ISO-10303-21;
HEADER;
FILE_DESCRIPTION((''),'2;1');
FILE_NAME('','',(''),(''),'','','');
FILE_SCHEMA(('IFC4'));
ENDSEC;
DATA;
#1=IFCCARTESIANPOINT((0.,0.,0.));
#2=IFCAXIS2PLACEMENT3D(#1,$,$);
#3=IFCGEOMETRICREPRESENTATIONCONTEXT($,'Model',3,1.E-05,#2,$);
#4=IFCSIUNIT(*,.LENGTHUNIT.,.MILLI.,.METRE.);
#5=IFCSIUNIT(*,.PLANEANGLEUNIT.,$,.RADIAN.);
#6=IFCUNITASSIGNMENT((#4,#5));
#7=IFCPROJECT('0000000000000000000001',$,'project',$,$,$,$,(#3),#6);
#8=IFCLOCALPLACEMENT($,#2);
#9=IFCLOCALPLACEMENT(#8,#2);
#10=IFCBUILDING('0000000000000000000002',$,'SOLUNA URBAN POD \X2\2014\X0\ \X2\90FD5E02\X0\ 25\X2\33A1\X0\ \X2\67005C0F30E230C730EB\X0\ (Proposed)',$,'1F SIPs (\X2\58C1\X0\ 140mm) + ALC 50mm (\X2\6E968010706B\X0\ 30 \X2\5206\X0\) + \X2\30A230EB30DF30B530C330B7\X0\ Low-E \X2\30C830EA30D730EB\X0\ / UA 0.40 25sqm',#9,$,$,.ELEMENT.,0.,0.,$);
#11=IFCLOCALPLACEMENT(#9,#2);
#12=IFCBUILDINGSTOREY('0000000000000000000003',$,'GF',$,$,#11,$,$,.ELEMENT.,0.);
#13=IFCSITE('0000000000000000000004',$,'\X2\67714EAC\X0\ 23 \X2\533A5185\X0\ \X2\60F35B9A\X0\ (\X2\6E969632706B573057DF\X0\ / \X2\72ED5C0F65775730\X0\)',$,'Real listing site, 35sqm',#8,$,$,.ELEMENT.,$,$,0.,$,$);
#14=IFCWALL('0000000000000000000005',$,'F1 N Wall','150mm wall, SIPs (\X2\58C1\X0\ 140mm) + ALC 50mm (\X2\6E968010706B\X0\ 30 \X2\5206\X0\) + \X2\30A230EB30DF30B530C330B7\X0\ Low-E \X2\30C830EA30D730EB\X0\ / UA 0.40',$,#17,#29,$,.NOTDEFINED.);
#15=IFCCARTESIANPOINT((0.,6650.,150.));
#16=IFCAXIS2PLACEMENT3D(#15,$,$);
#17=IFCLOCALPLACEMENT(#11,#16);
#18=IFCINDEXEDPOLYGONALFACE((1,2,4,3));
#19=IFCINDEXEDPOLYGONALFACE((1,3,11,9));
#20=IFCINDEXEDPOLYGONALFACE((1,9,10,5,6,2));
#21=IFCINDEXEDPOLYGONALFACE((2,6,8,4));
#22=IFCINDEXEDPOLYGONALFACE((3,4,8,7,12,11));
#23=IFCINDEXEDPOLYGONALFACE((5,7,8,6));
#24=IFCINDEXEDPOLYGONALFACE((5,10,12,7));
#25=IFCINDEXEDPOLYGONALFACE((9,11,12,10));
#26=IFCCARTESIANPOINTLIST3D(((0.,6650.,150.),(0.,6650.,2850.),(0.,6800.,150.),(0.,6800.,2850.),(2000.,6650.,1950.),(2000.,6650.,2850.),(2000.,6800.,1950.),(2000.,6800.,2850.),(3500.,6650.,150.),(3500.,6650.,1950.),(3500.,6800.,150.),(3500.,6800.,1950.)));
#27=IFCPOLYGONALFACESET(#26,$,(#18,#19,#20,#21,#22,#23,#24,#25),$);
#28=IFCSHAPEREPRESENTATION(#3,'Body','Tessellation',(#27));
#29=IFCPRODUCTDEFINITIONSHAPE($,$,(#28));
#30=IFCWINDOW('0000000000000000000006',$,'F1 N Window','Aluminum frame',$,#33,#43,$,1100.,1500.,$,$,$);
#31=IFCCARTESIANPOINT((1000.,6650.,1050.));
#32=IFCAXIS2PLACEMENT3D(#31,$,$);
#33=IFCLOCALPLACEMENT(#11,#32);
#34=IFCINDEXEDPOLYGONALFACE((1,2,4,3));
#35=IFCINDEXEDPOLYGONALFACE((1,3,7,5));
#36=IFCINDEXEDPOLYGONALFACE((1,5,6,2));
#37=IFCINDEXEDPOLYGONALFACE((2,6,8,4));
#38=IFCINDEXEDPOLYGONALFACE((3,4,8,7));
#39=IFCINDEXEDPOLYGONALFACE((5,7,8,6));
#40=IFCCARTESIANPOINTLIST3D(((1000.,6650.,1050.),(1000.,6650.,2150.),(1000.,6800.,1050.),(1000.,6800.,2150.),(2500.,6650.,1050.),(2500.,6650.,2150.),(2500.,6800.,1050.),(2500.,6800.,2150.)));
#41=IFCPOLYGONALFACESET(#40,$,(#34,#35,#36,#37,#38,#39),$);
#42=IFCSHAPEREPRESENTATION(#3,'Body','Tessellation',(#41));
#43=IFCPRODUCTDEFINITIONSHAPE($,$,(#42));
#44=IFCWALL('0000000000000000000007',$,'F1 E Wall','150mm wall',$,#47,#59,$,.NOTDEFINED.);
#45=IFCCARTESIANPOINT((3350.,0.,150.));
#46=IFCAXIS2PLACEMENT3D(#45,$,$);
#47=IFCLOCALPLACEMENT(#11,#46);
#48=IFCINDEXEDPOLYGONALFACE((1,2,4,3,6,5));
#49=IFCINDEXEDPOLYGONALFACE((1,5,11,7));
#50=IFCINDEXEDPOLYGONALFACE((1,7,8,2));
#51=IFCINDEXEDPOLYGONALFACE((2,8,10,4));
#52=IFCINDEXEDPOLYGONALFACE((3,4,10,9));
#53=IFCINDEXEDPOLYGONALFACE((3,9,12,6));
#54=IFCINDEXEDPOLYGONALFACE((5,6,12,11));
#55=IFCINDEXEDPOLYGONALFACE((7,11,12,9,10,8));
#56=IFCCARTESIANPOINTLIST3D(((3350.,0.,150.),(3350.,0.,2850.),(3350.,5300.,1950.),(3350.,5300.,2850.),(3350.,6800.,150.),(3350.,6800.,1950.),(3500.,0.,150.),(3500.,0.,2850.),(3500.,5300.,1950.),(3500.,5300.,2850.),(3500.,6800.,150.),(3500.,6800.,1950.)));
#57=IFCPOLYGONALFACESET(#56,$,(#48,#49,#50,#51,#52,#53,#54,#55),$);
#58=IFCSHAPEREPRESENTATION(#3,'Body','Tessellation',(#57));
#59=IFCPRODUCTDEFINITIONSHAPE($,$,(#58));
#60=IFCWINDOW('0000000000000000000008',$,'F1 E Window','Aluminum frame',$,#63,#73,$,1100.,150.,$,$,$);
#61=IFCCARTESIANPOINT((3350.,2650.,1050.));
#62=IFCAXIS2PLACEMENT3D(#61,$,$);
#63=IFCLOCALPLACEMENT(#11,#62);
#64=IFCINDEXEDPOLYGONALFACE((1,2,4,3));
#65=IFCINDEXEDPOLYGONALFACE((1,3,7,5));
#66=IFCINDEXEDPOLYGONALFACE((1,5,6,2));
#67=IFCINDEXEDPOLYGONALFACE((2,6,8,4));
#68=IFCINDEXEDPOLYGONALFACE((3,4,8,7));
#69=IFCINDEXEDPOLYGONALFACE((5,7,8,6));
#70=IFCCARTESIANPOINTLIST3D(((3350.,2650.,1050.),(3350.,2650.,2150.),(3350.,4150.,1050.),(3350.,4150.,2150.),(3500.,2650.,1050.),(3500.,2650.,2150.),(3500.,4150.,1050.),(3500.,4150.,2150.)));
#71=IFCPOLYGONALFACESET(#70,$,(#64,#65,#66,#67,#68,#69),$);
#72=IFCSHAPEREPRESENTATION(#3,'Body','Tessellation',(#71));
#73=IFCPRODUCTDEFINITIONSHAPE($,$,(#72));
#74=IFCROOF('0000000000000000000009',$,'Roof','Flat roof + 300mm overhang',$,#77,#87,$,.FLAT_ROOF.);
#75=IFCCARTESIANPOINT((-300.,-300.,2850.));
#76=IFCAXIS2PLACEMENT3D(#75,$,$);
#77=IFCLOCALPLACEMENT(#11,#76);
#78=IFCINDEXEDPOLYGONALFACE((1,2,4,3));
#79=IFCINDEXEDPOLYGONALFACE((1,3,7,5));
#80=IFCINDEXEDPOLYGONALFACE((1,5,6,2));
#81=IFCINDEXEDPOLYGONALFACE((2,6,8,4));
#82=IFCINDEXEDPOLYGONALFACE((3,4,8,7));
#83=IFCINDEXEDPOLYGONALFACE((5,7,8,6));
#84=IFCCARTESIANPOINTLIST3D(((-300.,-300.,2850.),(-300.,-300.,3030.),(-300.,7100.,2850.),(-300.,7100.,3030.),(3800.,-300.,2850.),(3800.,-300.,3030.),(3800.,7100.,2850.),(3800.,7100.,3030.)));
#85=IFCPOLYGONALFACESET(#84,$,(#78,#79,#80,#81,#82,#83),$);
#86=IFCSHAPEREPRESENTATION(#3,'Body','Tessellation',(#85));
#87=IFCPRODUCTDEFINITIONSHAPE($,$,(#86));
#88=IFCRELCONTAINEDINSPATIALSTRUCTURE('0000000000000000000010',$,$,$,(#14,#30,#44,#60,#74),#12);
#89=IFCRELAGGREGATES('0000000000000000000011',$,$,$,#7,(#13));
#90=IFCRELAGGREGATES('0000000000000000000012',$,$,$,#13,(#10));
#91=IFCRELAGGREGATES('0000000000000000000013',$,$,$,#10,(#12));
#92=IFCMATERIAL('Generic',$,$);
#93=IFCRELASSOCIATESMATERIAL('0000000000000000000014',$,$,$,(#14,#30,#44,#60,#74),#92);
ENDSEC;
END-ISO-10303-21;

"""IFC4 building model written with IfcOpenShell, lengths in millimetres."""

from ifc_helpers import new_model, si_unit, frame, frame_2d, origin, place, context, project, spatial, rectangle, extrude, material, element, fill, save


model = new_model("IFC4")

# Units and contexts
model_context = context("Model", 3, precision=1e-05, world=origin())
ifc_project = project(units=[si_unit("LENGTHUNIT", "METRE", prefix="MILLI"), si_unit("PLANEANGLEUNIT", "RADIAN")], contexts=[model_context])

# Site, building, storey
site_placement = place(None, origin())
site = spatial("IfcSite", under=ifc_project, at=site_placement, Name="東京 23 区内 想定 (準防火地域 / 狭小敷地)", ObjectType="Real listing site, 35sqm", CompositionType="ELEMENT", RefElevation=0.0)
building_placement = place(site_placement, origin())
building = spatial("IfcBuilding", under=site, at=building_placement, Name="SOLUNA URBAN POD — 都市 25㎡ 最小モデル (Proposed)", ObjectType="1F SIPs (壁 140mm) + ALC 50mm (準耐火 30 分) + アルミサッシ Low-E トリプル / UA 0.40 25sqm", CompositionType="ELEMENT", ElevationOfRefHeight=0.0, ElevationOfTerrain=0.0)
storey_placement = place(building_placement, origin())
storey = spatial("IfcBuildingStorey", under=building, at=storey_placement, Name="GF", CompositionType="ELEMENT", Elevation=0.0)

# Wall, opening, window
ifc_material_1 = material(Name="Generic")
wall_1_placement = place(storey_placement, frame((0.0, 6650.0, 150.0)))
wall_1 = element("IfcWall", 1, at=wall_1_placement, inside=storey, material=ifc_material_1, Name="F1 N Wall", Description="150mm wall, SIPs (壁 140mm) + ALC 50mm (準耐火 30 分) + アルミサッシ Low-E トリプル / UA 0.40", PredefinedType="NOTDEFINED", context=model_context, shape_type="SweptSolid", body=[
    extrude(rectangle(XDim=3500.0, YDim=150.0, at=frame_2d((1750.0, 75.0))), frame((0.0, 6650.0, 150.0)), (0.0, 0.0, 1.0), 2700.0),
])
opening_1_placement = place(storey_placement, frame((1000.0, 6650.0, 1050.0)))
opening_1 = element("IfcOpeningElement", 2, at=opening_1_placement, cuts=wall_1, PredefinedType="NOTDEFINED", context=model_context, shape_type="SweptSolid", body=[
    extrude(rectangle(XDim=1500.0, YDim=150.0, at=frame_2d((750.0, 75.0))), frame((1000.0, 6650.0, 1050.0)), (0.0, 0.0, 1.0), 1100.0),
])
window_1_placement = place(storey_placement, frame((1000.0, 6650.0, 1050.0)))
window_1 = element("IfcWindow", 3, at=window_1_placement, inside=storey, material=ifc_material_1, Name="F1 N Window", Description="Aluminum frame", OverallHeight=1100.0, OverallWidth=1500.0, context=model_context, shape_type="SweptSolid", body=[
    extrude(rectangle(XDim=1500.0, YDim=150.0, at=frame_2d((750.0, 75.0))), frame((1000.0, 6650.0, 1050.0)), (0.0, 0.0, 1.0), 1100.0),
])
fill(opening_1, window_1)

# Wall, opening, window
wall_2_placement = place(storey_placement, frame((3350.0, 0.0, 150.0)))
wall_2 = element("IfcWall", 4, at=wall_2_placement, inside=storey, material=ifc_material_1, Name="F1 E Wall", Description="150mm wall", PredefinedType="NOTDEFINED", context=model_context, shape_type="SweptSolid", body=[
    extrude(rectangle(XDim=150.0, YDim=6800.0, at=frame_2d((75.0, 3400.0))), frame((3350.0, 0.0, 150.0)), (0.0, 0.0, 1.0), 2700.0),
])
opening_2_placement = place(storey_placement, frame((3350.0, 2650.0, 1050.0)))
opening_2 = element("IfcOpeningElement", 5, at=opening_2_placement, cuts=wall_2, PredefinedType="NOTDEFINED", context=model_context, shape_type="SweptSolid", body=[
    extrude(rectangle(XDim=150.0, YDim=1500.0, at=frame_2d((75.0, 750.0))), frame((3350.0, 2650.0, 1050.0)), (0.0, 0.0, 1.0), 1100.0),
])
window_2_placement = place(storey_placement, frame((3350.0, 2650.0, 1050.0)))
window_2 = element("IfcWindow", 6, at=window_2_placement, inside=storey, material=ifc_material_1, Name="F1 E Window", Description="Aluminum frame", OverallHeight=1100.0, OverallWidth=150.0, context=model_context, shape_type="SweptSolid", body=[
    extrude(rectangle(XDim=150.0, YDim=1500.0, at=frame_2d((75.0, 750.0))), frame((3350.0, 2650.0, 1050.0)), (0.0, 0.0, 1.0), 1100.0),
])
fill(opening_2, window_2)

# Roof
roof_placement = place(storey_placement, frame((-300.0, -300.0, 2850.0)))
element("IfcRoof", 7, at=roof_placement, inside=storey, material=ifc_material_1, Name="Roof", Description="Flat roof + 300mm overhang", PredefinedType="FLAT_ROOF", context=model_context, shape_type="SweptSolid", body=[
    extrude(rectangle(XDim=4100.0, YDim=7400.0, at=frame_2d((2050.0, 3700.0))), frame((-300.0, -300.0, 2850.0)), (0.0, 0.0, 1.0), 180.0),
])

save(model, "model.ifc")
